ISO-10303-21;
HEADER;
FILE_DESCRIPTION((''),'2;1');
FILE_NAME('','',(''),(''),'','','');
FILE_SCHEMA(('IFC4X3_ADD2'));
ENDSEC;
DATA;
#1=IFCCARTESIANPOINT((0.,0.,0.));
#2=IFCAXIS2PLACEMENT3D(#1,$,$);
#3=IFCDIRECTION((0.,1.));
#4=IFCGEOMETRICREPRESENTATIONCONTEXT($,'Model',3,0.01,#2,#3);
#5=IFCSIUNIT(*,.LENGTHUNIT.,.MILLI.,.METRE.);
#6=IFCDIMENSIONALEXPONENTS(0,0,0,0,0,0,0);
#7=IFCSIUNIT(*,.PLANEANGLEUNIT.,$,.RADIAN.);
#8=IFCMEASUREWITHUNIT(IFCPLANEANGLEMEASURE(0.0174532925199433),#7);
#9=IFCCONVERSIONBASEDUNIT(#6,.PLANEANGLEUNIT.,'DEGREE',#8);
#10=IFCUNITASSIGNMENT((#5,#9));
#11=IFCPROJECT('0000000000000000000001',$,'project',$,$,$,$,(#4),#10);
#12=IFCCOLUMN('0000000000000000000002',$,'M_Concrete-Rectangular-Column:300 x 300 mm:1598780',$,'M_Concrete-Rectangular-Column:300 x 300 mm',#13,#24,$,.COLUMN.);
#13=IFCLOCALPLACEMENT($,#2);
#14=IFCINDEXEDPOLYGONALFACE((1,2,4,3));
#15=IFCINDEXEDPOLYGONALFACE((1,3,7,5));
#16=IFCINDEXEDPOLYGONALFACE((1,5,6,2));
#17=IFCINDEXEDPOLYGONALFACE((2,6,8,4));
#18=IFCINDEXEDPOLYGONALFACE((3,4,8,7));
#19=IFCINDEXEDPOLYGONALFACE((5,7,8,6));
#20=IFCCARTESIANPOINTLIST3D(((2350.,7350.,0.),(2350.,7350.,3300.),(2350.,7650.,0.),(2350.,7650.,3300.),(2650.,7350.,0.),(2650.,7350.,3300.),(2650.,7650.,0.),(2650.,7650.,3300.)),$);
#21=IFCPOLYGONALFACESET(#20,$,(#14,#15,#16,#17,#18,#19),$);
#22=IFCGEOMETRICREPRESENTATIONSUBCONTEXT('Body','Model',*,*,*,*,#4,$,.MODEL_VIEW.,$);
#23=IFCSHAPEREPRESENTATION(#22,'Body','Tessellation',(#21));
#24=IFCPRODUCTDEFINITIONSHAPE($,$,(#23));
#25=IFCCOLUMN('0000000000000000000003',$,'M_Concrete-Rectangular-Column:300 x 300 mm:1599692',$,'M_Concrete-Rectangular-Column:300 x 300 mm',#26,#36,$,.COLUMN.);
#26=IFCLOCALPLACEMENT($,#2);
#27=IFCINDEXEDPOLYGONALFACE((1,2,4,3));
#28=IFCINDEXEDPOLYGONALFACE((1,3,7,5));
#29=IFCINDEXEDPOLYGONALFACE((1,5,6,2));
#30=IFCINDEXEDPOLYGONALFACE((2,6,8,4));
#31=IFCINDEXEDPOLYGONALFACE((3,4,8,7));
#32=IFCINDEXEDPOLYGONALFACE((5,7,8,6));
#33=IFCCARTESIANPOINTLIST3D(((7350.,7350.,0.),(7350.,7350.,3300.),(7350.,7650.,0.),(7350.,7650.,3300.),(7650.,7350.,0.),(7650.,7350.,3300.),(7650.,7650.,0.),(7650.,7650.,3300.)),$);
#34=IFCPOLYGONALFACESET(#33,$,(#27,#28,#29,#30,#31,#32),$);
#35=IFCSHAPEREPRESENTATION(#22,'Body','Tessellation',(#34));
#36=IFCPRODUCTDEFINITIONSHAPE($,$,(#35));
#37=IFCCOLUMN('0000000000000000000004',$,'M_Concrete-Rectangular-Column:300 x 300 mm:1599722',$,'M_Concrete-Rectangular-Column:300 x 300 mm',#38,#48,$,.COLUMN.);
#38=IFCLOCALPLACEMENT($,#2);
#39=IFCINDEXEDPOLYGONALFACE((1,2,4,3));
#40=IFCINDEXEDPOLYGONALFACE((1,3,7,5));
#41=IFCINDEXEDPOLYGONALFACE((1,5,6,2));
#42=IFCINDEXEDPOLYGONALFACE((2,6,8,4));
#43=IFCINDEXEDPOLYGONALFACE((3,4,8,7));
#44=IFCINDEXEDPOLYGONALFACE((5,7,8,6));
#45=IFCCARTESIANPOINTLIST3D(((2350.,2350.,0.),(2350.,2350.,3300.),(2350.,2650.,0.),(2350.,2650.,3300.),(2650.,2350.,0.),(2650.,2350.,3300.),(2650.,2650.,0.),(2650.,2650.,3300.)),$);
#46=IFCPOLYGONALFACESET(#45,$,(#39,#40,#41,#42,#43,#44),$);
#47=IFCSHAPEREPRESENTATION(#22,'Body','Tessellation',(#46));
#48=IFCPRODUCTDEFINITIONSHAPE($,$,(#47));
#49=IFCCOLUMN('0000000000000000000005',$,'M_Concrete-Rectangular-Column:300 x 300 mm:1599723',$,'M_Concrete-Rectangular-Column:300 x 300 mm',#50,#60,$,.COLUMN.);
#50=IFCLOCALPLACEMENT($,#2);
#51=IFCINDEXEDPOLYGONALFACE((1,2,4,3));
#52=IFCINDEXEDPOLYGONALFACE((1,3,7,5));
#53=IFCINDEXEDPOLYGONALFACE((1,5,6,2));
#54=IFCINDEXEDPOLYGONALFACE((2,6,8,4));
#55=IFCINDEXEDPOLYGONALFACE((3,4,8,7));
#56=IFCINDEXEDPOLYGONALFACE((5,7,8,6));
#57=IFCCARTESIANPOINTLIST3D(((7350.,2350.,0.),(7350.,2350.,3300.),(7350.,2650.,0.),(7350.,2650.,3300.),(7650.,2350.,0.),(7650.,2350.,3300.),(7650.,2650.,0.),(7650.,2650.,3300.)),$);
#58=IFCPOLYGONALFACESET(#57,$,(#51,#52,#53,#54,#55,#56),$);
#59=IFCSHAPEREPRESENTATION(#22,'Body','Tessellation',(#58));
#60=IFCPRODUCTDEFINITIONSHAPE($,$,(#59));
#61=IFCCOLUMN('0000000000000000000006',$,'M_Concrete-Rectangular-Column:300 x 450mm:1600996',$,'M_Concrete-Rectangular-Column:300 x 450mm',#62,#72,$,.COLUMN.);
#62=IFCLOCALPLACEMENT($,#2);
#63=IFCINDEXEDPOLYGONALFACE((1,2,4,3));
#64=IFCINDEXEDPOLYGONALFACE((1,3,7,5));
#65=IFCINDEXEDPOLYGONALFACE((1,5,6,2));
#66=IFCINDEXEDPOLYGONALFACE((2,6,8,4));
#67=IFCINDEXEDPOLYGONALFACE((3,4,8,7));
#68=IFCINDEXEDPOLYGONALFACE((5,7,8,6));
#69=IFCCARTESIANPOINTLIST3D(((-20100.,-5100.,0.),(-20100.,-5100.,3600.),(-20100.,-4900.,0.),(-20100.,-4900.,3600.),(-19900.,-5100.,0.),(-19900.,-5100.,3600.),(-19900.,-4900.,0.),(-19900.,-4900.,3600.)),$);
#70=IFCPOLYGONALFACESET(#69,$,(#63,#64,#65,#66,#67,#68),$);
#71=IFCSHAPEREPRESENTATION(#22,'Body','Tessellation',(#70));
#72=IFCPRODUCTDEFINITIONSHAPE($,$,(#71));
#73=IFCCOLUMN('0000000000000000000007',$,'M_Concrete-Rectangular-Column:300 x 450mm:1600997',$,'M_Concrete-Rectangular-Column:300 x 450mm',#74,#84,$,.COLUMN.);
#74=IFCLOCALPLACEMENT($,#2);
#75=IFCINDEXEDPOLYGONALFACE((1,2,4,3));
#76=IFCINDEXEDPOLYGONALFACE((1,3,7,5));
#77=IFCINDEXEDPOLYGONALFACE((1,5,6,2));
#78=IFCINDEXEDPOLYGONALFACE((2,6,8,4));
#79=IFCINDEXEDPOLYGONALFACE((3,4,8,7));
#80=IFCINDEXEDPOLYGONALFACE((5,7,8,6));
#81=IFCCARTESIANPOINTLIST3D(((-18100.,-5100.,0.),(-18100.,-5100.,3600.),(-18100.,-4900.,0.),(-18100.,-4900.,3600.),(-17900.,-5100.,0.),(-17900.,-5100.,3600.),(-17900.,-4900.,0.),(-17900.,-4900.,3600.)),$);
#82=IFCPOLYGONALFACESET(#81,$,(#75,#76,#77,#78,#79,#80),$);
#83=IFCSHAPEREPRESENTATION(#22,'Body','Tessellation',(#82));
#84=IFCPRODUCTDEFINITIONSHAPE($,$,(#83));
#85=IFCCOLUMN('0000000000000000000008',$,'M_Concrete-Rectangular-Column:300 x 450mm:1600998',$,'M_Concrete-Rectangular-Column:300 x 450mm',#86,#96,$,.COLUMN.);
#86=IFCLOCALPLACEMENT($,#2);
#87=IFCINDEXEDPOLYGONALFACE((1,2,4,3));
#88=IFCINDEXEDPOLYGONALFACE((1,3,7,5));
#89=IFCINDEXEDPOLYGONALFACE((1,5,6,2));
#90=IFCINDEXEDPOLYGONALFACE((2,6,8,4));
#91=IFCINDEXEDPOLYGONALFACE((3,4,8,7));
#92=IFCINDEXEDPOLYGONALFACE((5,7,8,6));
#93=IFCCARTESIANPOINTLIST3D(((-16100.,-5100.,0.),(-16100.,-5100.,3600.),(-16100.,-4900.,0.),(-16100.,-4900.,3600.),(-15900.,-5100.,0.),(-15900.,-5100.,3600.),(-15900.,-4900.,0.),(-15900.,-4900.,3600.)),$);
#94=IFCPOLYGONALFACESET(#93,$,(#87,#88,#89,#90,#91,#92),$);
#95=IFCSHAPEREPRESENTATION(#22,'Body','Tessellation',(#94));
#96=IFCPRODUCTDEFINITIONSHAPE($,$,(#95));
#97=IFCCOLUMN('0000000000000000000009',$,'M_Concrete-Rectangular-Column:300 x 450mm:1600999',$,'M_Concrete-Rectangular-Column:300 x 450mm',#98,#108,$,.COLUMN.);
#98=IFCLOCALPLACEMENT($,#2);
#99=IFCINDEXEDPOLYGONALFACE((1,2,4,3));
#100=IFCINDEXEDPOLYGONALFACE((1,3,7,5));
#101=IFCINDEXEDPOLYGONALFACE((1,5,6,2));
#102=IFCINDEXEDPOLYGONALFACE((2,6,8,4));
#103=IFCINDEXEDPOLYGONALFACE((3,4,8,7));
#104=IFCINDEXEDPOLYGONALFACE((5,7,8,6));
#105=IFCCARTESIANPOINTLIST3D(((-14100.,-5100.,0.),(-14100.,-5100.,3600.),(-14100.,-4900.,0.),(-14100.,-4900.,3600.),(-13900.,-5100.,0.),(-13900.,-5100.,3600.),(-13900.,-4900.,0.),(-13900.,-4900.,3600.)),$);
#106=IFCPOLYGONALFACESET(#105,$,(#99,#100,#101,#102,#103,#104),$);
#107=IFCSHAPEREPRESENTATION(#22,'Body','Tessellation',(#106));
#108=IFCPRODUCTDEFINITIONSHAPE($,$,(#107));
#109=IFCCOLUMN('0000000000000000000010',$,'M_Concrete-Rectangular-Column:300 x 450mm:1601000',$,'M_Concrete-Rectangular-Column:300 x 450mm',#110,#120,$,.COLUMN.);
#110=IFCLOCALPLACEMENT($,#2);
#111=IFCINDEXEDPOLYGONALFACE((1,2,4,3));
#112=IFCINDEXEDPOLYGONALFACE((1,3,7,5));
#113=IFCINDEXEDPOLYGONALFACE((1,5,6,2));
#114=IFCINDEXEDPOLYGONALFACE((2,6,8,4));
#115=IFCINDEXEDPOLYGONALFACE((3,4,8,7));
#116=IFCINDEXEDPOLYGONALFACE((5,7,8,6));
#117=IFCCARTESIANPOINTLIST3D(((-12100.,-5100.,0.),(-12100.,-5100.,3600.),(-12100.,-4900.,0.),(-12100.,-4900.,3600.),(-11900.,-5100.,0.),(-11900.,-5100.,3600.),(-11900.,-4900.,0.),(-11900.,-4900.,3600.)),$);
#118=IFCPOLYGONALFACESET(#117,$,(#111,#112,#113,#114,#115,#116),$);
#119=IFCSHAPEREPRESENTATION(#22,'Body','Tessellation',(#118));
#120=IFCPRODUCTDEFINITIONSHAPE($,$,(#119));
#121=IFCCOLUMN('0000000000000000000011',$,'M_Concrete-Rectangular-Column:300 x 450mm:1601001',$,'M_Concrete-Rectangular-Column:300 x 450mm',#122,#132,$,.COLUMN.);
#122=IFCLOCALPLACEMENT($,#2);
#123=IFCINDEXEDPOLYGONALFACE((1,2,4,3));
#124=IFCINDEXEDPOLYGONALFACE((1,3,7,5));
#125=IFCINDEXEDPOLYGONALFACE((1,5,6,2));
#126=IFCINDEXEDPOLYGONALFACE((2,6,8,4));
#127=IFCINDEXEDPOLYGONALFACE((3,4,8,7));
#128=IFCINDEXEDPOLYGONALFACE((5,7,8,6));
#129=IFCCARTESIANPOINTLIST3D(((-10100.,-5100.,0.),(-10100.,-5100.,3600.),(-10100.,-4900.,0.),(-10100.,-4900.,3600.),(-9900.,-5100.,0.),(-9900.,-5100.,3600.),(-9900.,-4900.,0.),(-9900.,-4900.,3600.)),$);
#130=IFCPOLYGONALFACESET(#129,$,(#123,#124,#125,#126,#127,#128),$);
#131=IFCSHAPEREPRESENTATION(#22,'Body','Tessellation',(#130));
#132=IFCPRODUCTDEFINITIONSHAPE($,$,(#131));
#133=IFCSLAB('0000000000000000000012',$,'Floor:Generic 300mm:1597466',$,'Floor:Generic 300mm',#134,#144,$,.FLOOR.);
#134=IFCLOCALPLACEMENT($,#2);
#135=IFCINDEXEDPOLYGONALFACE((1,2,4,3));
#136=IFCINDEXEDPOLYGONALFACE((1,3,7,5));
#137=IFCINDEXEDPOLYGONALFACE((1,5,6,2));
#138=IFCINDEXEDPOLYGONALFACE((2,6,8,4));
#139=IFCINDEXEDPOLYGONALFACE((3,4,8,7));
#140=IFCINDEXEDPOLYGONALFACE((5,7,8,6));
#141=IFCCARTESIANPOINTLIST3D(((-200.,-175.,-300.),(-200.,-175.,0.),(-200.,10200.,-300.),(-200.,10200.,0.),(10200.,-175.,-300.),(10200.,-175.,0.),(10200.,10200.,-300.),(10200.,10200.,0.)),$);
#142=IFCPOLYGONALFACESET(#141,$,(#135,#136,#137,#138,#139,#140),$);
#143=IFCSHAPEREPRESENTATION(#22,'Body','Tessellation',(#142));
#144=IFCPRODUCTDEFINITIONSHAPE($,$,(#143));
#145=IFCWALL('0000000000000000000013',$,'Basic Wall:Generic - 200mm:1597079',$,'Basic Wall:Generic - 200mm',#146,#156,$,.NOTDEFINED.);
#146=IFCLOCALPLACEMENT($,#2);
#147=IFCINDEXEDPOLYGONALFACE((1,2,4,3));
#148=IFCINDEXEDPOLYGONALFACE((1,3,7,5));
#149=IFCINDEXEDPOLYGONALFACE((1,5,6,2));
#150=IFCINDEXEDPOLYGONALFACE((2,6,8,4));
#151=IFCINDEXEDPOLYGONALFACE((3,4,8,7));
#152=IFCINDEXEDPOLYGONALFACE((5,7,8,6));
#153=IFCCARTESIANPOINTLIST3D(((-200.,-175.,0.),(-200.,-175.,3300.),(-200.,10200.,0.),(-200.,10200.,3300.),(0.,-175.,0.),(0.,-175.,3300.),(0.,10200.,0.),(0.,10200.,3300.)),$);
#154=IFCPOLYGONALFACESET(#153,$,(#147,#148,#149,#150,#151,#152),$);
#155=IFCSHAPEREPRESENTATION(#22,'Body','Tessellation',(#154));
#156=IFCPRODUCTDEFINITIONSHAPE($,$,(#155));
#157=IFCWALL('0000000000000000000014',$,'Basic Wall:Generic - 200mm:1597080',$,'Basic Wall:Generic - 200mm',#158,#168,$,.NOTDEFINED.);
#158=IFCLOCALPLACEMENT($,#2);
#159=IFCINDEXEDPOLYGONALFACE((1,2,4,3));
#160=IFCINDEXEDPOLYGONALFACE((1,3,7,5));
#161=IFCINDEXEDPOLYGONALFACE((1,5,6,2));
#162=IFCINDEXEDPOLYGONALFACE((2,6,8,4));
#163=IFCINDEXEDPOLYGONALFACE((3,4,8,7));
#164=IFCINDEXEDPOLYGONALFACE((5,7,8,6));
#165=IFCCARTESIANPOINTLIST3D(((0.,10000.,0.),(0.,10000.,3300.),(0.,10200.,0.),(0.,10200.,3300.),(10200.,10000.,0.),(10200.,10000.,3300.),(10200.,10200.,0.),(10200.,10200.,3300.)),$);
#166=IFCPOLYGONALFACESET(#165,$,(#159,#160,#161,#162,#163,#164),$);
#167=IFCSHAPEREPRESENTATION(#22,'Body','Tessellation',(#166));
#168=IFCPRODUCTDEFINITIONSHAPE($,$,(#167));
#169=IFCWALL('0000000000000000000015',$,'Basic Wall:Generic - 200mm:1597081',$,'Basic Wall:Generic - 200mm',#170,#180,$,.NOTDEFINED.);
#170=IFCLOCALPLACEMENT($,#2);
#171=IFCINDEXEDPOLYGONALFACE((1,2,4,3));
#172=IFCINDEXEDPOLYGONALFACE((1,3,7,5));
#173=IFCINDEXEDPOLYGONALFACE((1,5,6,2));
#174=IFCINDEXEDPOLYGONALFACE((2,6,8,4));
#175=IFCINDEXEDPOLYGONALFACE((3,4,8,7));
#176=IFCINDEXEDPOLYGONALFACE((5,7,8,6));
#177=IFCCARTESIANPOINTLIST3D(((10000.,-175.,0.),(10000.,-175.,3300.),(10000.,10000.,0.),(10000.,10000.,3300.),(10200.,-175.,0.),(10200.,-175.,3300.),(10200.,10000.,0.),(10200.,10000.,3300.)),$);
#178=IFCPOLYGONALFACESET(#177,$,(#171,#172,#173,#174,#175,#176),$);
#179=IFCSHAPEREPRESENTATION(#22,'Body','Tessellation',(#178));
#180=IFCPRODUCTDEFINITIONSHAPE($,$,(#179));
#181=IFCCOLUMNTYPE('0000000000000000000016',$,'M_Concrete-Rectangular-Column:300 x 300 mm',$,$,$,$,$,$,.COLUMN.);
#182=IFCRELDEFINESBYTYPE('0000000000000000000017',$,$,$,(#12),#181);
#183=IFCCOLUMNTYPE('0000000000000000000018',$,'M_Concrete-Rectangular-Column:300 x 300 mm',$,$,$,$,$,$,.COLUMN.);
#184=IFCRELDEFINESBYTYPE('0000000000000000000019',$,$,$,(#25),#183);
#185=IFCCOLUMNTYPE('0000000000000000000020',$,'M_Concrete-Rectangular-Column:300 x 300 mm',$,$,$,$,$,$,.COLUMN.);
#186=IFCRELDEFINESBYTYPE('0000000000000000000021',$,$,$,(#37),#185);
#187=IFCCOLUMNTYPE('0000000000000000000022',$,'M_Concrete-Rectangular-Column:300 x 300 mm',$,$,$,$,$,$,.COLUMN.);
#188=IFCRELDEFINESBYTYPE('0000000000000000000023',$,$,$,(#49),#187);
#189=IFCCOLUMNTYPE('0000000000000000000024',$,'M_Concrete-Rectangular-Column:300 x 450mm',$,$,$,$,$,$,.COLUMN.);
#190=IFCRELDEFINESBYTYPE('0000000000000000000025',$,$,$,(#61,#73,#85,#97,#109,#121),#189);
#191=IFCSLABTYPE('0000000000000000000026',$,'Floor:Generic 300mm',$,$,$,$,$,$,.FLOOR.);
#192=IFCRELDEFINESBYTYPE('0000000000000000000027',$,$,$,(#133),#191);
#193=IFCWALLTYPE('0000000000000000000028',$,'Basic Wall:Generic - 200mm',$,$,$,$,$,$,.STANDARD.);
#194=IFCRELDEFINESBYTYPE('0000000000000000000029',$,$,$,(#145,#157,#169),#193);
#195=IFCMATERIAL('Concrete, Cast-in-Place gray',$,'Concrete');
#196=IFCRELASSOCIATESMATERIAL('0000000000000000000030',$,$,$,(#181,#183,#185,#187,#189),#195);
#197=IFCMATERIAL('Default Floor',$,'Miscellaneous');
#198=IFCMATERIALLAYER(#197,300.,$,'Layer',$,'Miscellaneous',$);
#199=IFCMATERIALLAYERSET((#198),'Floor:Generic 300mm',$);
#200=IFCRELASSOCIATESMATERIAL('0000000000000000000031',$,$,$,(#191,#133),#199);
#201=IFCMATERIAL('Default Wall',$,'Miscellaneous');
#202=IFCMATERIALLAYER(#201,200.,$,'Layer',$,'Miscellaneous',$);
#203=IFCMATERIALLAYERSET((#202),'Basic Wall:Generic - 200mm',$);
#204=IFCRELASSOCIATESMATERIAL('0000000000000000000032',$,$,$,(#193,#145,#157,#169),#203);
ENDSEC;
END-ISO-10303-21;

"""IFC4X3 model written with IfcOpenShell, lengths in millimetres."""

from ifc_helpers import new_model, entity, si_unit, converted_unit, direction, frame, frame_2d, origin, origin_2d_with_axis, place, context, subcontext, project, rectangle, extrude, source, transform, mapped, material, layer, layer_set, layer_usage, material_profile, profile_set, type_object, type_shapes, element, save


model = new_model("IFC4X3")

# Units and contexts
model_context = context("Model", 3, precision=0.01, world=origin(), true_north=direction((0.0, 1.0)))
body_context = subcontext(model_context, "Body", "Model", "MODEL_VIEW")
ifc_project = project(units=[si_unit("LENGTHUNIT", "METRE", prefix="MILLI"), converted_unit("PLANEANGLEUNIT", "DEGREE", entity("IfcPlaneAngleMeasure", 0.0174532925199433), si_unit("PLANEANGLEUNIT", "RADIAN"), dimensions=[0, 0, 0, 0, 0, 0, 0])], contexts=[model_context])

# Columns
ifc_material_1 = material(Name="Concrete, Cast-in-Place gray", Category="Concrete")
ifc_material_profile_1 = material_profile(ifc_material_1, rectangle(XDim=300.0, YDim=300.0, at=origin_2d_with_axis()), Name="300 x 300 mm")
ifc_profile_set_1 = profile_set([ifc_material_profile_1], Name="300 x 300 mm")
column_type_1 = type_object("IfcColumnType", Name="M_Concrete-Rectangular-Column:300 x 300 mm", PredefinedType="COLUMN", material=ifc_profile_set_1)
shared_shape_1 = source(origin(), body_context, "Body", "SweptSolid", [
    extrude(rectangle(XDim=300.0, YDim=300.0, at=origin_2d_with_axis()), frame((2500.0, 7500.0, 0.0)), (0.0, 0.0, 1.0), 3300.0),
])
type_shapes(column_type_1, [shared_shape_1])
placement_1 = place(None, origin())
placement_2 = place(placement_1, origin())
placement_3 = place(placement_2, origin())
column_1_placement = place(placement_3, origin())
element("IfcColumn", 1, at=column_1_placement, type_object=column_type_1, Name="M_Concrete-Rectangular-Column:300 x 300 mm:1598780", ObjectType="M_Concrete-Rectangular-Column:300 x 300 mm", PredefinedType="COLUMN", context=body_context, shape_type="MappedRepresentation", body=[
    mapped(shared_shape_1, transform((0.0, 0.0, 0.0), scale=1.0)),
])
column_type_2 = type_object("IfcColumnType", Name="M_Concrete-Rectangular-Column:300 x 300 mm", PredefinedType="COLUMN", material=ifc_profile_set_1)
shared_shape_2 = source(origin(), body_context, "Body", "SweptSolid", [
    extrude(rectangle(XDim=300.0, YDim=300.0, at=origin_2d_with_axis()), frame((7500.0, 7500.0, 0.0)), (0.0, 0.0, 1.0), 3300.0),
])
type_shapes(column_type_2, [shared_shape_2])
column_2_placement = place(placement_3, origin())
element("IfcColumn", 2, at=column_2_placement, type_object=column_type_2, Name="M_Concrete-Rectangular-Column:300 x 300 mm:1599692", ObjectType="M_Concrete-Rectangular-Column:300 x 300 mm", PredefinedType="COLUMN", context=body_context, shape_type="MappedRepresentation", body=[
    mapped(shared_shape_2, transform((0.0, 0.0, 0.0), scale=1.0)),
])
column_type_3 = type_object("IfcColumnType", Name="M_Concrete-Rectangular-Column:300 x 300 mm", PredefinedType="COLUMN", material=ifc_profile_set_1)
shared_shape_3 = source(origin(), body_context, "Body", "SweptSolid", [
    extrude(rectangle(XDim=300.0, YDim=300.0, at=origin_2d_with_axis()), frame((2500.0, 2500.0, 0.0)), (0.0, 0.0, 1.0), 3300.0),
])
type_shapes(column_type_3, [shared_shape_3])
column_3_placement = place(placement_3, origin())
element("IfcColumn", 3, at=column_3_placement, type_object=column_type_3, Name="M_Concrete-Rectangular-Column:300 x 300 mm:1599722", ObjectType="M_Concrete-Rectangular-Column:300 x 300 mm", PredefinedType="COLUMN", context=body_context, shape_type="MappedRepresentation", body=[
    mapped(shared_shape_3, transform((0.0, 0.0, 0.0), scale=1.0)),
])
column_type_4 = type_object("IfcColumnType", Name="M_Concrete-Rectangular-Column:300 x 300 mm", PredefinedType="COLUMN", material=ifc_profile_set_1)
shared_shape_4 = source(origin(), body_context, "Body", "SweptSolid", [
    extrude(rectangle(XDim=300.0, YDim=300.0, at=origin_2d_with_axis()), frame((7500.0, 2500.0, 0.0)), (0.0, 0.0, 1.0), 3300.0),
])
type_shapes(column_type_4, [shared_shape_4])
column_4_placement = place(placement_3, origin())
element("IfcColumn", 4, at=column_4_placement, type_object=column_type_4, Name="M_Concrete-Rectangular-Column:300 x 300 mm:1599723", ObjectType="M_Concrete-Rectangular-Column:300 x 300 mm", PredefinedType="COLUMN", context=body_context, shape_type="MappedRepresentation", body=[
    mapped(shared_shape_4, transform((0.0, 0.0, 0.0), scale=1.0)),
])
ifc_material_profile_2 = material_profile(ifc_material_1, rectangle(XDim=200.0, YDim=200.0, at=origin_2d_with_axis()), Name="300 x 450mm")
ifc_profile_set_2 = profile_set([ifc_material_profile_2], Name="300 x 450mm")
column_type_5 = type_object("IfcColumnType", Name="M_Concrete-Rectangular-Column:300 x 450mm", PredefinedType="COLUMN", material=ifc_profile_set_2)
shared_shape_5 = source(origin(), body_context, "Body", "SweptSolid", [
    extrude(rectangle(XDim=200.0, YDim=200.0, at=origin_2d_with_axis()), frame((0.0, 0.0, 0.0), z_axis=(0.0, 0.0, 1.0), x_axis=(-1.0, 0.0, 0.0)), (0.0, 0.0, 1.0), 3600.0),
])
type_shapes(column_type_5, [shared_shape_5])
for number, where, z_axis, x_axis, name in (
    (5, (-20000.0, -5000.0, 0.0), (0.0, 0.0, 1.0), (0.0, -1.0, 0.0), "M_Concrete-Rectangular-Column:300 x 450mm:1600996"),
    (6, (-18000.0, -5000.0, 0.0), (0.0, 0.0, 1.0), (0.0, -1.0, 0.0), "M_Concrete-Rectangular-Column:300 x 450mm:1600997"),
    (7, (-16000.0, -5000.0, 0.0), (0.0, 0.0, 1.0), (0.0, -1.0, 0.0), "M_Concrete-Rectangular-Column:300 x 450mm:1600998"),
    (8, (-14000.0, -5000.0, 0.0), (0.0, 0.0, 1.0), (0.0, -1.0, 0.0), "M_Concrete-Rectangular-Column:300 x 450mm:1600999"),
    (9, (-12000.0, -5000.0, 0.0), (0.0, 0.0, 1.0), (0.0, -1.0, 0.0), "M_Concrete-Rectangular-Column:300 x 450mm:1601000"),
    (10, (-10000.0, -5000.0, 0.0), (0.0, 0.0, 1.0), (0.0, -1.0, 0.0), "M_Concrete-Rectangular-Column:300 x 450mm:1601001"),
):
    element("IfcColumn", number, at=place(placement_3, frame(where, z_axis=z_axis, x_axis=x_axis)), type_object=column_type_5, Name=name, ObjectType="M_Concrete-Rectangular-Column:300 x 450mm", PredefinedType="COLUMN", context=body_context, shape_type="MappedRepresentation", body=[
        mapped(shared_shape_5, transform((0.0, 0.0, 0.0), scale=1.0)),
    ])

# Slab
ifc_material_2 = material(Name="Default Floor", Category="Miscellaneous")
ifc_layer_1 = layer(ifc_material_2, 300.0, Name="Layer", Category="Miscellaneous")
ifc_layer_set_1 = layer_set([ifc_layer_1], Name="Floor:Generic 300mm")
ifc_layer_usage = layer_usage(ifc_layer_set_1, "AXIS3", "POSITIVE", 0.0)
slab_type = type_object("IfcSlabType", Name="Floor:Generic 300mm", PredefinedType="FLOOR", material=ifc_layer_set_1)
slab_placement = place(placement_3, origin())
element("IfcSlab", 11, at=slab_placement, type_object=slab_type, material=ifc_layer_usage, Name="Floor:Generic 300mm:1597466", ObjectType="Floor:Generic 300mm", PredefinedType="FLOOR", context=body_context, shape_type="SweptSolid", body=[
    extrude(rectangle(XDim=10375.0, YDim=10400.0, at=origin_2d_with_axis()), frame((5000.0, 5012.5, 0.0), z_axis=(0.0, 0.0, -1.0), x_axis=(0.0, 1.0, 0.0)), (0.0, 0.0, 1.0), 300.0),
])

# Walls
ifc_material_3 = material(Name="Default Wall", Category="Miscellaneous")
ifc_layer_2 = layer(ifc_material_3, 200.0, Name="Layer", Category="Miscellaneous")
ifc_layer_set_2 = layer_set([ifc_layer_2], Name="Basic Wall:Generic - 200mm")
wall_type_1 = type_object("IfcWallType", Name="Basic Wall:Generic - 200mm", PredefinedType="STANDARD", material=ifc_layer_set_2)
wall_1_placement = place(placement_3, frame((-100.0, 10200.0, 0.0), z_axis=(0.0, 0.0, 1.0), x_axis=(0.0, -1.0, 0.0)))
element("IfcWall", 12, at=wall_1_placement, type_object=wall_type_1, material=ifc_layer_set_2, Name="Basic Wall:Generic - 200mm:1597079", ObjectType="Basic Wall:Generic - 200mm", PredefinedType="NOTDEFINED", context=body_context, shape_type="SweptSolid", body=[
    extrude(rectangle(XDim=10375.0, YDim=200.0, at=frame_2d((5187.5, 0.0), x_axis=(-1.0, 0.0))), origin(), (0.0, 0.0, 1.0), 3300.0),
])
wall_2_placement = place(placement_3, frame((10200.0, 10100.0, 0.0), z_axis=(0.0, 0.0, 1.0), x_axis=(-1.0, 0.0, 0.0)))
element("IfcWall", 13, at=wall_2_placement, type_object=wall_type_1, material=ifc_layer_set_2, Name="Basic Wall:Generic - 200mm:1597080", ObjectType="Basic Wall:Generic - 200mm", PredefinedType="NOTDEFINED", context=body_context, shape_type="SweptSolid", body=[
    extrude(rectangle(XDim=10200.0, YDim=200.0, at=frame_2d((5100.0, 0.0), x_axis=(-1.0, 0.0))), origin(), (0.0, 0.0, 1.0), 3300.0),
])
wall_3_placement = place(placement_3, frame((10100.0, -175.0, 0.0), z_axis=(0.0, 0.0, 1.0), x_axis=(0.0, 1.0, 0.0)))
element("IfcWall", 14, at=wall_3_placement, type_object=wall_type_1, material=ifc_layer_set_2, Name="Basic Wall:Generic - 200mm:1597081", ObjectType="Basic Wall:Generic - 200mm", PredefinedType="NOTDEFINED", context=body_context, shape_type="SweptSolid", body=[
    extrude(rectangle(XDim=10175.0, YDim=200.0, at=frame_2d((5087.5, 0.0), x_axis=(-1.0, 0.0))), origin(), (0.0, 0.0, 1.0), 3300.0),
])

save(model, "model.ifc")
